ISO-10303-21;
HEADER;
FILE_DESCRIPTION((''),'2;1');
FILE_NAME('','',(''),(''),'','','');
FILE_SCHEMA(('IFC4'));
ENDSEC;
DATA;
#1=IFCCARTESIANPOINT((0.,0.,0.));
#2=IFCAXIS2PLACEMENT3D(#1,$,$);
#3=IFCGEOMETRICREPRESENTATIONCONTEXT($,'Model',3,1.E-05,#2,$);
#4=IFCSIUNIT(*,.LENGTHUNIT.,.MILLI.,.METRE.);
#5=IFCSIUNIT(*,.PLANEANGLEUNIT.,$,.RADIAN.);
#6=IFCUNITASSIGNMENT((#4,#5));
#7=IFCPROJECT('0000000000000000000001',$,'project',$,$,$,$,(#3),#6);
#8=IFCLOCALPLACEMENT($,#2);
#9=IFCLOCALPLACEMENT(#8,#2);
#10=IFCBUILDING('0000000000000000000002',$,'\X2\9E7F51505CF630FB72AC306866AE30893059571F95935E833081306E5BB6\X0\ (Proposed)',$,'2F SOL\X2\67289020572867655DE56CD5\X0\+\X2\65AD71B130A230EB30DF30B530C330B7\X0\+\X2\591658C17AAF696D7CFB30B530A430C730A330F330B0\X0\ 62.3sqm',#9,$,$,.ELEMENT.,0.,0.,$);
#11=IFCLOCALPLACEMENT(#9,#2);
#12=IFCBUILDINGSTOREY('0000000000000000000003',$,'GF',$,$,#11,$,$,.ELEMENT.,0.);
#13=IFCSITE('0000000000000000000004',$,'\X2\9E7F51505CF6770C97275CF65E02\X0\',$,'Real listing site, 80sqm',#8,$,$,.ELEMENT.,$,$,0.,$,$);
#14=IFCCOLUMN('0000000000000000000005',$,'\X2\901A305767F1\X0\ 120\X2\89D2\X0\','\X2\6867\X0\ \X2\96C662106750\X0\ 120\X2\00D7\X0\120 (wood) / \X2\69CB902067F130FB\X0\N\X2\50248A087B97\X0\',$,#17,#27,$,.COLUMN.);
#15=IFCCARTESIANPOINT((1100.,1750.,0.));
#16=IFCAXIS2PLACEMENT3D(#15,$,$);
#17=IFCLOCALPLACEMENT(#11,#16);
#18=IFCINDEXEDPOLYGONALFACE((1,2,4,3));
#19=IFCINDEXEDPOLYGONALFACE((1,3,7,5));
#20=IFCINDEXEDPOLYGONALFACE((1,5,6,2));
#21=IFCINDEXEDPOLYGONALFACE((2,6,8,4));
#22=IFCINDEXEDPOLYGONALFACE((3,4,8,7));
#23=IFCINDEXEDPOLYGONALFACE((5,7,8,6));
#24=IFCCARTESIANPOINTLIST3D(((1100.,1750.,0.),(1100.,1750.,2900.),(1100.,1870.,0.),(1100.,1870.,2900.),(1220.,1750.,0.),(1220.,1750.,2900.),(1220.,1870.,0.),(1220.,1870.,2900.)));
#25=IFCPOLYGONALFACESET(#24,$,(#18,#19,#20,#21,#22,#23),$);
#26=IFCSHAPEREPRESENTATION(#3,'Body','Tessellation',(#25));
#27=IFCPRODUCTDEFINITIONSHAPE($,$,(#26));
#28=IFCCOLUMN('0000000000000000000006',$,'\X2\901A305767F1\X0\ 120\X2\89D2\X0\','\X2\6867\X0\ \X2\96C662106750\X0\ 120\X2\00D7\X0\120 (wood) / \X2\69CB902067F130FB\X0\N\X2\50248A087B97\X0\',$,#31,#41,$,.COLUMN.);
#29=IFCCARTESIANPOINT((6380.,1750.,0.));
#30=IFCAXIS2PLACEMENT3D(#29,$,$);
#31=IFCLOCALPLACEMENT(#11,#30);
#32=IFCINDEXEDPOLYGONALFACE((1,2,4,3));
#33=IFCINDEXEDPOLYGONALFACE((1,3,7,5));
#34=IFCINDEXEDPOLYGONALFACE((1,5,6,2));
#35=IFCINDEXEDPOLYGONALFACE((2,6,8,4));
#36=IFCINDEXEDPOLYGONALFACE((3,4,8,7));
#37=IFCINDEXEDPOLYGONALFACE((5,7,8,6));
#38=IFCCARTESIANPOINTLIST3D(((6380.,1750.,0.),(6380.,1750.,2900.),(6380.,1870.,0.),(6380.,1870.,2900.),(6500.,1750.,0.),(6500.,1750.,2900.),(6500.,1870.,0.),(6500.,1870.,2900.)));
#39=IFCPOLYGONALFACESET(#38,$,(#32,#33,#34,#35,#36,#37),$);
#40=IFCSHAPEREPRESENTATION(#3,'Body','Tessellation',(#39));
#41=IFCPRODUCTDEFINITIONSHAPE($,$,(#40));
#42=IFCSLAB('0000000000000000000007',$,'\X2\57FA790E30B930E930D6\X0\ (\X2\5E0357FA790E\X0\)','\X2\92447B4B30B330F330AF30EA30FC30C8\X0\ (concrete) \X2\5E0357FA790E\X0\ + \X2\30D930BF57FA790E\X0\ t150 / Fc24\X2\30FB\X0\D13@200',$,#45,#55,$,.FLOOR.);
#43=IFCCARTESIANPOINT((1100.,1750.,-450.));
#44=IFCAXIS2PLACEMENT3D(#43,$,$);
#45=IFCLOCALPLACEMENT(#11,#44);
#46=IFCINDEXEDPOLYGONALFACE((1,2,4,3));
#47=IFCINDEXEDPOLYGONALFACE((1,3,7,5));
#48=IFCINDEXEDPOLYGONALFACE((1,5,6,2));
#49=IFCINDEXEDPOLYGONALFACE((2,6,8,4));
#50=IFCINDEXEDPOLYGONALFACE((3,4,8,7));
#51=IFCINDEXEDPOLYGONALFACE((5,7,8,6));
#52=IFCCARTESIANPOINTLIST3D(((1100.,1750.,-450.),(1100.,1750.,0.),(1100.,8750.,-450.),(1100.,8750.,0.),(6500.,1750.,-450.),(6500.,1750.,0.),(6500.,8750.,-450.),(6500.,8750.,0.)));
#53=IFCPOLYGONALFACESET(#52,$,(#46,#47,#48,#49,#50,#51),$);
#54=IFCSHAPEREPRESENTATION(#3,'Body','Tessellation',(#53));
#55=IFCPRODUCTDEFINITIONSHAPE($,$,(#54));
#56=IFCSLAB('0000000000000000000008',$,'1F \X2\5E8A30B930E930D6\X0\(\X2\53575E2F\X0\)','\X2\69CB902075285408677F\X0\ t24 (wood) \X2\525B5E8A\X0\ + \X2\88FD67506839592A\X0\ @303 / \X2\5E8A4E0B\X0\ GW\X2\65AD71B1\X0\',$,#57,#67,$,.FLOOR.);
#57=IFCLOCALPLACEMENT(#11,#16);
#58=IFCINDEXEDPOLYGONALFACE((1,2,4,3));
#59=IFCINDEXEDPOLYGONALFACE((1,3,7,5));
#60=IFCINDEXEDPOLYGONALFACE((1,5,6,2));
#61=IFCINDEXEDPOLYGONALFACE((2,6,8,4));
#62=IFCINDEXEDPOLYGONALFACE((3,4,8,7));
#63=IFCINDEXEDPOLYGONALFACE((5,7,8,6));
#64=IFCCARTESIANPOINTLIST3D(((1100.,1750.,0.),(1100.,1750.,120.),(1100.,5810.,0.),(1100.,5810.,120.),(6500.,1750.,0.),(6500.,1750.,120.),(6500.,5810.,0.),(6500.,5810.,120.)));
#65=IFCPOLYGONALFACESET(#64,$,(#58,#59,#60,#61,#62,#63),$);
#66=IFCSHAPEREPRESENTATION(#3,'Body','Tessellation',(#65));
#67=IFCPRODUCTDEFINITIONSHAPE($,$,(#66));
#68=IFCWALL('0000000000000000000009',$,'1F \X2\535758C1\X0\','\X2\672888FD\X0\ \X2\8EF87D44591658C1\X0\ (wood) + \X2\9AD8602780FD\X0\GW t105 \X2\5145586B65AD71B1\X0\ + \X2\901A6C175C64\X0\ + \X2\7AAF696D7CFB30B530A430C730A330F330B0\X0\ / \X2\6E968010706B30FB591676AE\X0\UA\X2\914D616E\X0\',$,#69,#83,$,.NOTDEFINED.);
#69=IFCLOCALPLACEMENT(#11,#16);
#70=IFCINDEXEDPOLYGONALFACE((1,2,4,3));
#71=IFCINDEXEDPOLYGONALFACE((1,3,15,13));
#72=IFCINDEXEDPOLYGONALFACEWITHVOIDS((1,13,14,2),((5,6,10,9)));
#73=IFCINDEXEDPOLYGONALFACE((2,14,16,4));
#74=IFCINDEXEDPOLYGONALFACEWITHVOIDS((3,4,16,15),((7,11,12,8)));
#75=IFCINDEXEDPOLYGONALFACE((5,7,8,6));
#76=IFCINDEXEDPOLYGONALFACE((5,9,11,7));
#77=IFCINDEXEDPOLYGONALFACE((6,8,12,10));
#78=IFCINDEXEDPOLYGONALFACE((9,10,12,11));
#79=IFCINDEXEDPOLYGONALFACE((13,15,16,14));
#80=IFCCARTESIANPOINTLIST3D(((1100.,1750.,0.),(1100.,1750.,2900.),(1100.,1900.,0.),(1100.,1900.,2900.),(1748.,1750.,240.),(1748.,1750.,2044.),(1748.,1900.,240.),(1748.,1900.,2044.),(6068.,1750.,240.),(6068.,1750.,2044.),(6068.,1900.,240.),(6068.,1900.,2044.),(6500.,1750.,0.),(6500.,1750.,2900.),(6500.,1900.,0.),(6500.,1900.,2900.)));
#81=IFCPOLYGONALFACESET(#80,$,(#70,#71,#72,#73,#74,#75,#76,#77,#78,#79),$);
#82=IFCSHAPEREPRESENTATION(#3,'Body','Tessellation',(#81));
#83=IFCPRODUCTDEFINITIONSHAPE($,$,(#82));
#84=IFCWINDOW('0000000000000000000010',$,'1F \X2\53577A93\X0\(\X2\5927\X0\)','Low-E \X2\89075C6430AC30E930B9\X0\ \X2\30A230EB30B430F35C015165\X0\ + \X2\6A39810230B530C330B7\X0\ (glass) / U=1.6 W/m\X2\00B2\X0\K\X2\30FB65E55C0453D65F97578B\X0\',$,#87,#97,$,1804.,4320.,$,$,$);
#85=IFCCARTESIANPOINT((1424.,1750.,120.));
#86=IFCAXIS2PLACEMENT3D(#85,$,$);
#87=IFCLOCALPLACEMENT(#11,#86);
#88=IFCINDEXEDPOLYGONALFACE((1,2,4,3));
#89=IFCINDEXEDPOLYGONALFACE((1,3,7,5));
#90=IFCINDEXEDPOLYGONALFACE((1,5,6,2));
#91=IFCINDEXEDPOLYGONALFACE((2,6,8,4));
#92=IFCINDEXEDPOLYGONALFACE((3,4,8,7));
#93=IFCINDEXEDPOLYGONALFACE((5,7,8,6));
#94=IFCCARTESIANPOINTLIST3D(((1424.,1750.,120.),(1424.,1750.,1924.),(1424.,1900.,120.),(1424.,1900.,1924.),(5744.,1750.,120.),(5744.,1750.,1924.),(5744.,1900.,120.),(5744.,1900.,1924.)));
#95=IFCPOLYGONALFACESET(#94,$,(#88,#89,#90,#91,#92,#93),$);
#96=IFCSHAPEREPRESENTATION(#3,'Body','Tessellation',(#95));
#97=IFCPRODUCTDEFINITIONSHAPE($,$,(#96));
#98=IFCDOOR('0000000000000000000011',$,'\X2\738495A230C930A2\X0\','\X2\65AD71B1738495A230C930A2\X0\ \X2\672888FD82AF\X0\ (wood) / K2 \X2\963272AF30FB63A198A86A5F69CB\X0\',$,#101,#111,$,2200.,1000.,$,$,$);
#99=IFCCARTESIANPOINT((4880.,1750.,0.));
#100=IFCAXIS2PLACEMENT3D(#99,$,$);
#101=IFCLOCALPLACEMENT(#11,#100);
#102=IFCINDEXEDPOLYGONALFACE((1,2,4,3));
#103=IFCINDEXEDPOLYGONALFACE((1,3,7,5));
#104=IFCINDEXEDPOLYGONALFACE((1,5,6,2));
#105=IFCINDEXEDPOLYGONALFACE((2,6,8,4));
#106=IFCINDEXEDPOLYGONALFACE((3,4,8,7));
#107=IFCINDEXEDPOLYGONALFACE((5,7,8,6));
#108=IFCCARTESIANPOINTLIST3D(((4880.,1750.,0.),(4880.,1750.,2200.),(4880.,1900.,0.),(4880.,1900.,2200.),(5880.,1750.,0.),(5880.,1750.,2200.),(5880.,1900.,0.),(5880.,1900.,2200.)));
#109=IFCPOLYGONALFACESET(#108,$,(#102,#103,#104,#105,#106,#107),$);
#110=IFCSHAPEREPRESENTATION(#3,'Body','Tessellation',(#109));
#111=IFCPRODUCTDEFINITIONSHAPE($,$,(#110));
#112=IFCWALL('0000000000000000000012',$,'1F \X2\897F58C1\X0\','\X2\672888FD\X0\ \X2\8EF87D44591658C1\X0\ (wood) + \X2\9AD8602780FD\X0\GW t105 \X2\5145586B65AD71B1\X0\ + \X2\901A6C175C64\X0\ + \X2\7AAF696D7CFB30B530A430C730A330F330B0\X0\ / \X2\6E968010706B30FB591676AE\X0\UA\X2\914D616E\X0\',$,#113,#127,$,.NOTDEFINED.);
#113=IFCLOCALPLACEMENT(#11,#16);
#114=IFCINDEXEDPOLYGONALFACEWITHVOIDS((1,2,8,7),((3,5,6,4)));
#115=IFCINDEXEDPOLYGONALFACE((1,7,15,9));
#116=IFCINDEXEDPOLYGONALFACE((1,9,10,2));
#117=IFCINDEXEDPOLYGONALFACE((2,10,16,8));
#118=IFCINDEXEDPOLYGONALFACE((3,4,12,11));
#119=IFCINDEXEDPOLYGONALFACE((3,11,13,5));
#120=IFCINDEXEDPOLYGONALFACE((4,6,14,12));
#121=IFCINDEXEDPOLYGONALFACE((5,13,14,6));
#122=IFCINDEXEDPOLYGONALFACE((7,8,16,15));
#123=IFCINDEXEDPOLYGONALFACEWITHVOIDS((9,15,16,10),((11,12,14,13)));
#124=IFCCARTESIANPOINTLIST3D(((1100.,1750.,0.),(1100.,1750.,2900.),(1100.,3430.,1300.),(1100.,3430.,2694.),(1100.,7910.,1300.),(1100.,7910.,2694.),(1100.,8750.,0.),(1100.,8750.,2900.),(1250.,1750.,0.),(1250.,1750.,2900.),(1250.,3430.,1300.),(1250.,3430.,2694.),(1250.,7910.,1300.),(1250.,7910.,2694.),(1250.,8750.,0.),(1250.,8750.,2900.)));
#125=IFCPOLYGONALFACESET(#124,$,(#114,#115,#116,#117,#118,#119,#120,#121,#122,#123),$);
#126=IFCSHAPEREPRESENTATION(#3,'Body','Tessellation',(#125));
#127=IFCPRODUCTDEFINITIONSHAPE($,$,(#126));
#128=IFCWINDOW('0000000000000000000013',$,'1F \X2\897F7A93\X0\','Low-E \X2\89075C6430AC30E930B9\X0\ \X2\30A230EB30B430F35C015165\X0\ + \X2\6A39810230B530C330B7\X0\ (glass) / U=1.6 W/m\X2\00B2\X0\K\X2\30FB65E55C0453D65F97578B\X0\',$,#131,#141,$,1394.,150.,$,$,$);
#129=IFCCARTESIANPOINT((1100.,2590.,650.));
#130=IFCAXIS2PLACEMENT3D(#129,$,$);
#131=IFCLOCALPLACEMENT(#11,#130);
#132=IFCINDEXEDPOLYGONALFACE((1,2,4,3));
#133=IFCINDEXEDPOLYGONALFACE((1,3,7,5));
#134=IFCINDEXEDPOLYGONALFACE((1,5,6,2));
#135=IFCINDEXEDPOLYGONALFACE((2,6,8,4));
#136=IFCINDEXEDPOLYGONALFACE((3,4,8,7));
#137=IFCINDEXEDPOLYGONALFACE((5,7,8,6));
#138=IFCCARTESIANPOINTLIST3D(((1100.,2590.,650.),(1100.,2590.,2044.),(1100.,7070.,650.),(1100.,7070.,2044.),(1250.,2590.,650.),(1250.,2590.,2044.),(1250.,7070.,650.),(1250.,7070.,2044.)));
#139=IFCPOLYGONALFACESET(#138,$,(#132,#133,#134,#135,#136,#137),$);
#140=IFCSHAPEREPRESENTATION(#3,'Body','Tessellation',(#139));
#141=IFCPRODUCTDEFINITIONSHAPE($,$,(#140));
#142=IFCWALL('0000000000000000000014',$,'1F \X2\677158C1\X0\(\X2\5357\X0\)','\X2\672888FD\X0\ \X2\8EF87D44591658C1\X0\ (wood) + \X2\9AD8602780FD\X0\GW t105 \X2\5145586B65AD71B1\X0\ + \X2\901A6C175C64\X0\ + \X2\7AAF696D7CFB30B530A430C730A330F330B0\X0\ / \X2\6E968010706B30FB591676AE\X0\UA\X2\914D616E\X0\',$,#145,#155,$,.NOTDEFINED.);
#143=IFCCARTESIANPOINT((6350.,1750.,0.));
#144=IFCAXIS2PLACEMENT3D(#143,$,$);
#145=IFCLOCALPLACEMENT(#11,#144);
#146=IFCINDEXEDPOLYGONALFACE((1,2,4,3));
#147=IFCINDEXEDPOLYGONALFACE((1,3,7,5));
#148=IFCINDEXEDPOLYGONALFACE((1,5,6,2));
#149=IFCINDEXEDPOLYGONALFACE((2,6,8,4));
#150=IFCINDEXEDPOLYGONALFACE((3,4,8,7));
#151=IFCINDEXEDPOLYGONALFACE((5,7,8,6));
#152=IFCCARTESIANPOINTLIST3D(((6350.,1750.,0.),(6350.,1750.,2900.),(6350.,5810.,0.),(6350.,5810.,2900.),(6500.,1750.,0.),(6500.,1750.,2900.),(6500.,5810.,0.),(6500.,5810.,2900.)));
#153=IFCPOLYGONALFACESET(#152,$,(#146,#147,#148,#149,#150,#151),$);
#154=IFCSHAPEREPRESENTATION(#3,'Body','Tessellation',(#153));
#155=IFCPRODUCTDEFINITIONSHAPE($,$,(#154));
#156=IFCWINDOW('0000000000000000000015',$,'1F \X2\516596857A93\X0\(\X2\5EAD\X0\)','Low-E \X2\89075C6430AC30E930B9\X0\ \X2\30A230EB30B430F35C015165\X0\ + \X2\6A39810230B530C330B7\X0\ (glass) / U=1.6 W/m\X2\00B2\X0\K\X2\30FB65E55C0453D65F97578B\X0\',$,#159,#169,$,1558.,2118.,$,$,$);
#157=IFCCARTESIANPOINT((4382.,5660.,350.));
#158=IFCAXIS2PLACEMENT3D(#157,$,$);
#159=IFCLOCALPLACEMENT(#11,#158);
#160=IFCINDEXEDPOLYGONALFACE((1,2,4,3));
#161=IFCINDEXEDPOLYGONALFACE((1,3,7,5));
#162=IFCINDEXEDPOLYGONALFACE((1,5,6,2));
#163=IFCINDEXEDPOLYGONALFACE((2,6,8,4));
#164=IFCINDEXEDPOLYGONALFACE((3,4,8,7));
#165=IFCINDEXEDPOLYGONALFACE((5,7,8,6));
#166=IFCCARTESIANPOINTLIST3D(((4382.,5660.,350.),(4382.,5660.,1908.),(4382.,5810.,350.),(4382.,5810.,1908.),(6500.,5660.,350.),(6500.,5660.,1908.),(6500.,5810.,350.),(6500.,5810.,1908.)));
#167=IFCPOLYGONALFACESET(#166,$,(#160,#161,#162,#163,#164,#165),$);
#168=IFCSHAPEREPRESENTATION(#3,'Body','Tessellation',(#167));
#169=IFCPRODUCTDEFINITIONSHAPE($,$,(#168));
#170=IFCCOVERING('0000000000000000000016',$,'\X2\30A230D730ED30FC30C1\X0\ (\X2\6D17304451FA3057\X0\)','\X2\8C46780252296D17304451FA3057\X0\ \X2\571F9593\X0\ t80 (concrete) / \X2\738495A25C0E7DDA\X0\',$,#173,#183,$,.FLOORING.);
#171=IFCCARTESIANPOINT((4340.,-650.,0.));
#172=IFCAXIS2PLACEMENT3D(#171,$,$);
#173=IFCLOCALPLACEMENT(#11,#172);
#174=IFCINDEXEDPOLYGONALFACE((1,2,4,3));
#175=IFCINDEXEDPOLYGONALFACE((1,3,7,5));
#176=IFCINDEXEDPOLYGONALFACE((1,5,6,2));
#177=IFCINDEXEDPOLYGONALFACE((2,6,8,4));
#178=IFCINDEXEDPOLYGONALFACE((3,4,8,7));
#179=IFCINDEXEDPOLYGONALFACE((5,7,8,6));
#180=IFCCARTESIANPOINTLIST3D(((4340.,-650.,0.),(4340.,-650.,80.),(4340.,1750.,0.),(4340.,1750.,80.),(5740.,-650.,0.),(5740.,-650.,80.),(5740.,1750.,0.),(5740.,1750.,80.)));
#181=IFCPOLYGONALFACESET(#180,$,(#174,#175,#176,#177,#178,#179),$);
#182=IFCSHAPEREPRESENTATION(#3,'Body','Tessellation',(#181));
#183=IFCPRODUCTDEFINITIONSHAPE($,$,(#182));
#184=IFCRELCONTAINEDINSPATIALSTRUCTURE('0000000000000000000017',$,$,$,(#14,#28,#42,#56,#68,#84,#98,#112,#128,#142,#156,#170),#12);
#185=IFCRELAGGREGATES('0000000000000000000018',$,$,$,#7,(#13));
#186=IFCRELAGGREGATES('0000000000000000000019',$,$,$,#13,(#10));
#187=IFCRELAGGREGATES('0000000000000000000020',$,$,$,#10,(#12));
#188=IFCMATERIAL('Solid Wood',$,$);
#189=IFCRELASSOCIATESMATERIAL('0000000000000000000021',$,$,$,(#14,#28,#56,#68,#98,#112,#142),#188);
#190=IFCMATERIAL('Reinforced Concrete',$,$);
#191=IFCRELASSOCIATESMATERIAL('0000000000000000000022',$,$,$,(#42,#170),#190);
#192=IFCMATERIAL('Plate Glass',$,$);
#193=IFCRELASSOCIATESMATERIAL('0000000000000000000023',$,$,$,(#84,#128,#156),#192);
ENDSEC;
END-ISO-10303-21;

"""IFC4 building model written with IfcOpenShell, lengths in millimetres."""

from ifc_helpers import new_model, si_unit, frame, frame_2d, origin, place, context, project, spatial, rectangle, extrude, material, element, fill, save


model = new_model("IFC4")

# Units and contexts
model_context = context("Model", 3, precision=1e-05, world=origin())
ifc_project = project(units=[si_unit("LENGTHUNIT", "METRE", prefix="MILLI"), si_unit("PLANEANGLEUNIT", "RADIAN")], contexts=[model_context])

# Site, building, storey
site_placement = place(None, origin())
site = spatial("IfcSite", under=ifc_project, at=site_placement, Name="鹿児島県霧島市", ObjectType="Real listing site, 80sqm", CompositionType="ELEMENT", RefElevation=0.0)
building_placement = place(site_placement, origin())
building = spatial("IfcBuilding", under=site, at=building_placement, Name="鹿児島・犬と暮らす土間広めの家 (Proposed)", ObjectType="2F SOL木造在来工法+断熱アルミサッシ+外壁窯業系サイディング 62.3sqm", CompositionType="ELEMENT", ElevationOfRefHeight=0.0, ElevationOfTerrain=0.0)
storey_placement = place(building_placement, origin())
storey = spatial("IfcBuildingStorey", under=building, at=storey_placement, Name="GF", CompositionType="ELEMENT", Elevation=0.0)

# Columns
ifc_material_1 = material(Name="Solid Wood")
column_1_placement = place(storey_placement, frame((1100.0, 1750.0, 0.0)))
element("IfcColumn", 1, at=column_1_placement, inside=storey, material=ifc_material_1, Name="通し柱 120角", Description="桧 集成材 120×120 (wood) / 構造柱・N値計算", PredefinedType="COLUMN", context=model_context, shape_type="SweptSolid", body=[
    extrude(rectangle(XDim=120.0, YDim=120.0, at=frame_2d((60.0, 60.0))), frame((1100.0, 1750.0, 0.0)), (0.0, 0.0, 1.0), 2900.0),
])
column_2_placement = place(storey_placement, frame((6380.0, 1750.0, 0.0)))
element("IfcColumn", 2, at=column_2_placement, inside=storey, material=ifc_material_1, Name="通し柱 120角", Description="桧 集成材 120×120 (wood) / 構造柱・N値計算", PredefinedType="COLUMN", context=model_context, shape_type="SweptSolid", body=[
    extrude(rectangle(XDim=120.0, YDim=120.0, at=frame_2d((60.0, 60.0))), frame((6380.0, 1750.0, 0.0)), (0.0, 0.0, 1.0), 2900.0),
])

# Slabs
ifc_material_2 = material(Name="Reinforced Concrete")
slab_1_placement = place(storey_placement, frame((1100.0, 1750.0, -450.0)))
element("IfcSlab", 3, at=slab_1_placement, inside=storey, material=ifc_material_2, Name="基礎スラブ (布基礎)", Description="鉄筋コンクリート (concrete) 布基礎 + ベタ基礎 t150 / Fc24・D13@200", PredefinedType="FLOOR", context=model_context, shape_type="SweptSolid", body=[
    extrude(rectangle(XDim=5400.0, YDim=7000.0, at=frame_2d((2700.0, 3500.0))), frame((1100.0, 1750.0, -450.0)), (0.0, 0.0, 1.0), 450.0),
])
slab_2_placement = place(storey_placement, frame((1100.0, 1750.0, 0.0)))
element("IfcSlab", 4, at=slab_2_placement, inside=storey, material=ifc_material_1, Name="1F 床スラブ(南帯)", Description="構造用合板 t24 (wood) 剛床 + 製材根太 @303 / 床下 GW断熱", PredefinedType="FLOOR", context=model_context, shape_type="SweptSolid", body=[
    extrude(rectangle(XDim=5400.0, YDim=4060.0, at=frame_2d((2700.0, 2030.0))), frame((1100.0, 1750.0, 0.0)), (0.0, 0.0, 1.0), 120.0),
])

# Wall, openings, window, door
wall_1_placement = place(storey_placement, frame((1100.0, 1750.0, 0.0)))
wall_1 = element("IfcWall", 5, at=wall_1_placement, inside=storey, material=ifc_material_1, Name="1F 南壁", Description="木製 軸組外壁 (wood) + 高性能GW t105 充填断熱 + 通気層 + 窯業系サイディング / 準耐火・外皮UA配慮", PredefinedType="NOTDEFINED", context=model_context, shape_type="SweptSolid", body=[
    extrude(rectangle(XDim=5400.0, YDim=150.0, at=frame_2d((2700.0, 75.0))), frame((1100.0, 1750.0, 0.0)), (0.0, 0.0, 1.0), 2900.0),
])
opening_1_placement = place(storey_placement, frame((1424.0, 1750.0, 120.0)))
opening_1 = element("IfcOpeningElement", 6, at=opening_1_placement, cuts=wall_1, PredefinedType="NOTDEFINED", context=model_context, shape_type="SweptSolid", body=[
    extrude(rectangle(XDim=4320.0, YDim=150.0, at=frame_2d((2160.0, 75.0))), frame((1424.0, 1750.0, 120.0)), (0.0, 0.0, 1.0), 1804.0),
])
opening_2_placement = place(storey_placement, frame((4880.0, 1750.0, 0.0)))
opening_2 = element("IfcOpeningElement", 7, at=opening_2_placement, cuts=wall_1, PredefinedType="NOTDEFINED", context=model_context, shape_type="SweptSolid", body=[
    extrude(rectangle(XDim=1000.0, YDim=150.0, at=frame_2d((500.0, 75.0))), frame((4880.0, 1750.0, 0.0)), (0.0, 0.0, 1.0), 2200.0),
])
ifc_material_3 = material(Name="Plate Glass")
window_1_placement = place(storey_placement, frame((1424.0, 1750.0, 120.0)))
window_1 = element("IfcWindow", 8, at=window_1_placement, inside=storey, material=ifc_material_3, Name="1F 南窓(大)", Description="Low-E 複層ガラス アルゴン封入 + 樹脂サッシ (glass) / U=1.6 W/m²K・日射取得型", OverallHeight=1804.0, OverallWidth=4320.0, context=model_context, shape_type="SweptSolid", body=[
    extrude(rectangle(XDim=4320.0, YDim=150.0, at=frame_2d((2160.0, 75.0))), frame((1424.0, 1750.0, 120.0)), (0.0, 0.0, 1.0), 1804.0),
])
fill(opening_1, window_1)
door_1_placement = place(storey_placement, frame((4880.0, 1750.0, 0.0)))
door_1 = element("IfcDoor", 9, at=door_1_placement, inside=storey, material=ifc_material_1, Name="玄関ドア", Description="断熱玄関ドア 木製芯 (wood) / K2 防犯・採風機構", OverallHeight=2200.0, OverallWidth=1000.0, context=model_context, shape_type="SweptSolid", body=[
    extrude(rectangle(XDim=1000.0, YDim=150.0, at=frame_2d((500.0, 75.0))), frame((4880.0, 1750.0, 0.0)), (0.0, 0.0, 1.0), 2200.0),
])
fill(opening_2, door_1)

# Walls, openings, windows
wall_2_placement = place(storey_placement, frame((1100.0, 1750.0, 0.0)))
wall_2 = element("IfcWall", 10, at=wall_2_placement, inside=storey, material=ifc_material_1, Name="1F 西壁", Description="木製 軸組外壁 (wood) + 高性能GW t105 充填断熱 + 通気層 + 窯業系サイディング / 準耐火・外皮UA配慮", PredefinedType="NOTDEFINED", context=model_context, shape_type="SweptSolid", body=[
    extrude(rectangle(XDim=150.0, YDim=7000.0, at=frame_2d((75.0, 3500.0))), frame((1100.0, 1750.0, 0.0)), (0.0, 0.0, 1.0), 2900.0),
])
opening_3_placement = place(storey_placement, frame((1100.0, 2590.0, 650.0)))
opening_3 = element("IfcOpeningElement", 11, at=opening_3_placement, cuts=wall_2, PredefinedType="NOTDEFINED", context=model_context, shape_type="SweptSolid", body=[
    extrude(rectangle(XDim=150.0, YDim=4480.0, at=frame_2d((75.0, 2240.0))), frame((1100.0, 2590.0, 650.0)), (0.0, 0.0, 1.0), 1394.0),
])
window_2_placement = place(storey_placement, frame((1100.0, 2590.0, 650.0)))
window_2 = element("IfcWindow", 12, at=window_2_placement, inside=storey, material=ifc_material_3, Name="1F 西窓", Description="Low-E 複層ガラス アルゴン封入 + 樹脂サッシ (glass) / U=1.6 W/m²K・日射取得型", OverallHeight=1394.0, OverallWidth=150.0, context=model_context, shape_type="SweptSolid", body=[
    extrude(rectangle(XDim=150.0, YDim=4480.0, at=frame_2d((75.0, 2240.0))), frame((1100.0, 2590.0, 650.0)), (0.0, 0.0, 1.0), 1394.0),
])
fill(opening_3, window_2)
wall_3_placement = place(storey_placement, frame((6350.0, 1750.0, 0.0)))
wall_3 = element("IfcWall", 13, at=wall_3_placement, inside=storey, material=ifc_material_1, Name="1F 東壁(南)", Description="木製 軸組外壁 (wood) + 高性能GW t105 充填断熱 + 通気層 + 窯業系サイディング / 準耐火・外皮UA配慮", PredefinedType="NOTDEFINED", context=model_context, shape_type="SweptSolid", body=[
    extrude(rectangle(XDim=150.0, YDim=4060.0, at=frame_2d((75.0, 2030.0))), frame((6350.0, 1750.0, 0.0)), (0.0, 0.0, 1.0), 2900.0),
])
opening_4_placement = place(storey_placement, frame((4382.0, 5660.0, 350.0)))
opening_4 = element("IfcOpeningElement", 14, at=opening_4_placement, cuts=wall_3, PredefinedType="NOTDEFINED", context=model_context, shape_type="SweptSolid", body=[
    extrude(rectangle(XDim=2118.0, YDim=150.0, at=frame_2d((1059.0, 75.0))), frame((4382.0, 5660.0, 350.0)), (0.0, 0.0, 1.0), 1558.0),
])
window_3_placement = place(storey_placement, frame((4382.0, 5660.0, 350.0)))
window_3 = element("IfcWindow", 15, at=window_3_placement, inside=storey, material=ifc_material_3, Name="1F 入隅窓(庭)", Description="Low-E 複層ガラス アルゴン封入 + 樹脂サッシ (glass) / U=1.6 W/m²K・日射取得型", OverallHeight=1558.0, OverallWidth=2118.0, context=model_context, shape_type="SweptSolid", body=[
    extrude(rectangle(XDim=2118.0, YDim=150.0, at=frame_2d((1059.0, 75.0))), frame((4382.0, 5660.0, 350.0)), (0.0, 0.0, 1.0), 1558.0),
])
fill(opening_4, window_3)

# Covering
covering_1_placement = place(storey_placement, frame((4340.0, -650.0, 0.0)))
element("IfcCovering", 16, at=covering_1_placement, inside=storey, material=ifc_material_2, Name="アプローチ (洗い出し)", Description="豆砂利洗い出し 土間 t80 (concrete) / 玄関導線", PredefinedType="FLOORING", context=model_context, shape_type="SweptSolid", body=[
    extrude(rectangle(XDim=1400.0, YDim=2400.0, at=frame_2d((700.0, 1200.0))), frame((4340.0, -650.0, 0.0)), (0.0, 0.0, 1.0), 80.0),
])

save(model, "model.ifc")
